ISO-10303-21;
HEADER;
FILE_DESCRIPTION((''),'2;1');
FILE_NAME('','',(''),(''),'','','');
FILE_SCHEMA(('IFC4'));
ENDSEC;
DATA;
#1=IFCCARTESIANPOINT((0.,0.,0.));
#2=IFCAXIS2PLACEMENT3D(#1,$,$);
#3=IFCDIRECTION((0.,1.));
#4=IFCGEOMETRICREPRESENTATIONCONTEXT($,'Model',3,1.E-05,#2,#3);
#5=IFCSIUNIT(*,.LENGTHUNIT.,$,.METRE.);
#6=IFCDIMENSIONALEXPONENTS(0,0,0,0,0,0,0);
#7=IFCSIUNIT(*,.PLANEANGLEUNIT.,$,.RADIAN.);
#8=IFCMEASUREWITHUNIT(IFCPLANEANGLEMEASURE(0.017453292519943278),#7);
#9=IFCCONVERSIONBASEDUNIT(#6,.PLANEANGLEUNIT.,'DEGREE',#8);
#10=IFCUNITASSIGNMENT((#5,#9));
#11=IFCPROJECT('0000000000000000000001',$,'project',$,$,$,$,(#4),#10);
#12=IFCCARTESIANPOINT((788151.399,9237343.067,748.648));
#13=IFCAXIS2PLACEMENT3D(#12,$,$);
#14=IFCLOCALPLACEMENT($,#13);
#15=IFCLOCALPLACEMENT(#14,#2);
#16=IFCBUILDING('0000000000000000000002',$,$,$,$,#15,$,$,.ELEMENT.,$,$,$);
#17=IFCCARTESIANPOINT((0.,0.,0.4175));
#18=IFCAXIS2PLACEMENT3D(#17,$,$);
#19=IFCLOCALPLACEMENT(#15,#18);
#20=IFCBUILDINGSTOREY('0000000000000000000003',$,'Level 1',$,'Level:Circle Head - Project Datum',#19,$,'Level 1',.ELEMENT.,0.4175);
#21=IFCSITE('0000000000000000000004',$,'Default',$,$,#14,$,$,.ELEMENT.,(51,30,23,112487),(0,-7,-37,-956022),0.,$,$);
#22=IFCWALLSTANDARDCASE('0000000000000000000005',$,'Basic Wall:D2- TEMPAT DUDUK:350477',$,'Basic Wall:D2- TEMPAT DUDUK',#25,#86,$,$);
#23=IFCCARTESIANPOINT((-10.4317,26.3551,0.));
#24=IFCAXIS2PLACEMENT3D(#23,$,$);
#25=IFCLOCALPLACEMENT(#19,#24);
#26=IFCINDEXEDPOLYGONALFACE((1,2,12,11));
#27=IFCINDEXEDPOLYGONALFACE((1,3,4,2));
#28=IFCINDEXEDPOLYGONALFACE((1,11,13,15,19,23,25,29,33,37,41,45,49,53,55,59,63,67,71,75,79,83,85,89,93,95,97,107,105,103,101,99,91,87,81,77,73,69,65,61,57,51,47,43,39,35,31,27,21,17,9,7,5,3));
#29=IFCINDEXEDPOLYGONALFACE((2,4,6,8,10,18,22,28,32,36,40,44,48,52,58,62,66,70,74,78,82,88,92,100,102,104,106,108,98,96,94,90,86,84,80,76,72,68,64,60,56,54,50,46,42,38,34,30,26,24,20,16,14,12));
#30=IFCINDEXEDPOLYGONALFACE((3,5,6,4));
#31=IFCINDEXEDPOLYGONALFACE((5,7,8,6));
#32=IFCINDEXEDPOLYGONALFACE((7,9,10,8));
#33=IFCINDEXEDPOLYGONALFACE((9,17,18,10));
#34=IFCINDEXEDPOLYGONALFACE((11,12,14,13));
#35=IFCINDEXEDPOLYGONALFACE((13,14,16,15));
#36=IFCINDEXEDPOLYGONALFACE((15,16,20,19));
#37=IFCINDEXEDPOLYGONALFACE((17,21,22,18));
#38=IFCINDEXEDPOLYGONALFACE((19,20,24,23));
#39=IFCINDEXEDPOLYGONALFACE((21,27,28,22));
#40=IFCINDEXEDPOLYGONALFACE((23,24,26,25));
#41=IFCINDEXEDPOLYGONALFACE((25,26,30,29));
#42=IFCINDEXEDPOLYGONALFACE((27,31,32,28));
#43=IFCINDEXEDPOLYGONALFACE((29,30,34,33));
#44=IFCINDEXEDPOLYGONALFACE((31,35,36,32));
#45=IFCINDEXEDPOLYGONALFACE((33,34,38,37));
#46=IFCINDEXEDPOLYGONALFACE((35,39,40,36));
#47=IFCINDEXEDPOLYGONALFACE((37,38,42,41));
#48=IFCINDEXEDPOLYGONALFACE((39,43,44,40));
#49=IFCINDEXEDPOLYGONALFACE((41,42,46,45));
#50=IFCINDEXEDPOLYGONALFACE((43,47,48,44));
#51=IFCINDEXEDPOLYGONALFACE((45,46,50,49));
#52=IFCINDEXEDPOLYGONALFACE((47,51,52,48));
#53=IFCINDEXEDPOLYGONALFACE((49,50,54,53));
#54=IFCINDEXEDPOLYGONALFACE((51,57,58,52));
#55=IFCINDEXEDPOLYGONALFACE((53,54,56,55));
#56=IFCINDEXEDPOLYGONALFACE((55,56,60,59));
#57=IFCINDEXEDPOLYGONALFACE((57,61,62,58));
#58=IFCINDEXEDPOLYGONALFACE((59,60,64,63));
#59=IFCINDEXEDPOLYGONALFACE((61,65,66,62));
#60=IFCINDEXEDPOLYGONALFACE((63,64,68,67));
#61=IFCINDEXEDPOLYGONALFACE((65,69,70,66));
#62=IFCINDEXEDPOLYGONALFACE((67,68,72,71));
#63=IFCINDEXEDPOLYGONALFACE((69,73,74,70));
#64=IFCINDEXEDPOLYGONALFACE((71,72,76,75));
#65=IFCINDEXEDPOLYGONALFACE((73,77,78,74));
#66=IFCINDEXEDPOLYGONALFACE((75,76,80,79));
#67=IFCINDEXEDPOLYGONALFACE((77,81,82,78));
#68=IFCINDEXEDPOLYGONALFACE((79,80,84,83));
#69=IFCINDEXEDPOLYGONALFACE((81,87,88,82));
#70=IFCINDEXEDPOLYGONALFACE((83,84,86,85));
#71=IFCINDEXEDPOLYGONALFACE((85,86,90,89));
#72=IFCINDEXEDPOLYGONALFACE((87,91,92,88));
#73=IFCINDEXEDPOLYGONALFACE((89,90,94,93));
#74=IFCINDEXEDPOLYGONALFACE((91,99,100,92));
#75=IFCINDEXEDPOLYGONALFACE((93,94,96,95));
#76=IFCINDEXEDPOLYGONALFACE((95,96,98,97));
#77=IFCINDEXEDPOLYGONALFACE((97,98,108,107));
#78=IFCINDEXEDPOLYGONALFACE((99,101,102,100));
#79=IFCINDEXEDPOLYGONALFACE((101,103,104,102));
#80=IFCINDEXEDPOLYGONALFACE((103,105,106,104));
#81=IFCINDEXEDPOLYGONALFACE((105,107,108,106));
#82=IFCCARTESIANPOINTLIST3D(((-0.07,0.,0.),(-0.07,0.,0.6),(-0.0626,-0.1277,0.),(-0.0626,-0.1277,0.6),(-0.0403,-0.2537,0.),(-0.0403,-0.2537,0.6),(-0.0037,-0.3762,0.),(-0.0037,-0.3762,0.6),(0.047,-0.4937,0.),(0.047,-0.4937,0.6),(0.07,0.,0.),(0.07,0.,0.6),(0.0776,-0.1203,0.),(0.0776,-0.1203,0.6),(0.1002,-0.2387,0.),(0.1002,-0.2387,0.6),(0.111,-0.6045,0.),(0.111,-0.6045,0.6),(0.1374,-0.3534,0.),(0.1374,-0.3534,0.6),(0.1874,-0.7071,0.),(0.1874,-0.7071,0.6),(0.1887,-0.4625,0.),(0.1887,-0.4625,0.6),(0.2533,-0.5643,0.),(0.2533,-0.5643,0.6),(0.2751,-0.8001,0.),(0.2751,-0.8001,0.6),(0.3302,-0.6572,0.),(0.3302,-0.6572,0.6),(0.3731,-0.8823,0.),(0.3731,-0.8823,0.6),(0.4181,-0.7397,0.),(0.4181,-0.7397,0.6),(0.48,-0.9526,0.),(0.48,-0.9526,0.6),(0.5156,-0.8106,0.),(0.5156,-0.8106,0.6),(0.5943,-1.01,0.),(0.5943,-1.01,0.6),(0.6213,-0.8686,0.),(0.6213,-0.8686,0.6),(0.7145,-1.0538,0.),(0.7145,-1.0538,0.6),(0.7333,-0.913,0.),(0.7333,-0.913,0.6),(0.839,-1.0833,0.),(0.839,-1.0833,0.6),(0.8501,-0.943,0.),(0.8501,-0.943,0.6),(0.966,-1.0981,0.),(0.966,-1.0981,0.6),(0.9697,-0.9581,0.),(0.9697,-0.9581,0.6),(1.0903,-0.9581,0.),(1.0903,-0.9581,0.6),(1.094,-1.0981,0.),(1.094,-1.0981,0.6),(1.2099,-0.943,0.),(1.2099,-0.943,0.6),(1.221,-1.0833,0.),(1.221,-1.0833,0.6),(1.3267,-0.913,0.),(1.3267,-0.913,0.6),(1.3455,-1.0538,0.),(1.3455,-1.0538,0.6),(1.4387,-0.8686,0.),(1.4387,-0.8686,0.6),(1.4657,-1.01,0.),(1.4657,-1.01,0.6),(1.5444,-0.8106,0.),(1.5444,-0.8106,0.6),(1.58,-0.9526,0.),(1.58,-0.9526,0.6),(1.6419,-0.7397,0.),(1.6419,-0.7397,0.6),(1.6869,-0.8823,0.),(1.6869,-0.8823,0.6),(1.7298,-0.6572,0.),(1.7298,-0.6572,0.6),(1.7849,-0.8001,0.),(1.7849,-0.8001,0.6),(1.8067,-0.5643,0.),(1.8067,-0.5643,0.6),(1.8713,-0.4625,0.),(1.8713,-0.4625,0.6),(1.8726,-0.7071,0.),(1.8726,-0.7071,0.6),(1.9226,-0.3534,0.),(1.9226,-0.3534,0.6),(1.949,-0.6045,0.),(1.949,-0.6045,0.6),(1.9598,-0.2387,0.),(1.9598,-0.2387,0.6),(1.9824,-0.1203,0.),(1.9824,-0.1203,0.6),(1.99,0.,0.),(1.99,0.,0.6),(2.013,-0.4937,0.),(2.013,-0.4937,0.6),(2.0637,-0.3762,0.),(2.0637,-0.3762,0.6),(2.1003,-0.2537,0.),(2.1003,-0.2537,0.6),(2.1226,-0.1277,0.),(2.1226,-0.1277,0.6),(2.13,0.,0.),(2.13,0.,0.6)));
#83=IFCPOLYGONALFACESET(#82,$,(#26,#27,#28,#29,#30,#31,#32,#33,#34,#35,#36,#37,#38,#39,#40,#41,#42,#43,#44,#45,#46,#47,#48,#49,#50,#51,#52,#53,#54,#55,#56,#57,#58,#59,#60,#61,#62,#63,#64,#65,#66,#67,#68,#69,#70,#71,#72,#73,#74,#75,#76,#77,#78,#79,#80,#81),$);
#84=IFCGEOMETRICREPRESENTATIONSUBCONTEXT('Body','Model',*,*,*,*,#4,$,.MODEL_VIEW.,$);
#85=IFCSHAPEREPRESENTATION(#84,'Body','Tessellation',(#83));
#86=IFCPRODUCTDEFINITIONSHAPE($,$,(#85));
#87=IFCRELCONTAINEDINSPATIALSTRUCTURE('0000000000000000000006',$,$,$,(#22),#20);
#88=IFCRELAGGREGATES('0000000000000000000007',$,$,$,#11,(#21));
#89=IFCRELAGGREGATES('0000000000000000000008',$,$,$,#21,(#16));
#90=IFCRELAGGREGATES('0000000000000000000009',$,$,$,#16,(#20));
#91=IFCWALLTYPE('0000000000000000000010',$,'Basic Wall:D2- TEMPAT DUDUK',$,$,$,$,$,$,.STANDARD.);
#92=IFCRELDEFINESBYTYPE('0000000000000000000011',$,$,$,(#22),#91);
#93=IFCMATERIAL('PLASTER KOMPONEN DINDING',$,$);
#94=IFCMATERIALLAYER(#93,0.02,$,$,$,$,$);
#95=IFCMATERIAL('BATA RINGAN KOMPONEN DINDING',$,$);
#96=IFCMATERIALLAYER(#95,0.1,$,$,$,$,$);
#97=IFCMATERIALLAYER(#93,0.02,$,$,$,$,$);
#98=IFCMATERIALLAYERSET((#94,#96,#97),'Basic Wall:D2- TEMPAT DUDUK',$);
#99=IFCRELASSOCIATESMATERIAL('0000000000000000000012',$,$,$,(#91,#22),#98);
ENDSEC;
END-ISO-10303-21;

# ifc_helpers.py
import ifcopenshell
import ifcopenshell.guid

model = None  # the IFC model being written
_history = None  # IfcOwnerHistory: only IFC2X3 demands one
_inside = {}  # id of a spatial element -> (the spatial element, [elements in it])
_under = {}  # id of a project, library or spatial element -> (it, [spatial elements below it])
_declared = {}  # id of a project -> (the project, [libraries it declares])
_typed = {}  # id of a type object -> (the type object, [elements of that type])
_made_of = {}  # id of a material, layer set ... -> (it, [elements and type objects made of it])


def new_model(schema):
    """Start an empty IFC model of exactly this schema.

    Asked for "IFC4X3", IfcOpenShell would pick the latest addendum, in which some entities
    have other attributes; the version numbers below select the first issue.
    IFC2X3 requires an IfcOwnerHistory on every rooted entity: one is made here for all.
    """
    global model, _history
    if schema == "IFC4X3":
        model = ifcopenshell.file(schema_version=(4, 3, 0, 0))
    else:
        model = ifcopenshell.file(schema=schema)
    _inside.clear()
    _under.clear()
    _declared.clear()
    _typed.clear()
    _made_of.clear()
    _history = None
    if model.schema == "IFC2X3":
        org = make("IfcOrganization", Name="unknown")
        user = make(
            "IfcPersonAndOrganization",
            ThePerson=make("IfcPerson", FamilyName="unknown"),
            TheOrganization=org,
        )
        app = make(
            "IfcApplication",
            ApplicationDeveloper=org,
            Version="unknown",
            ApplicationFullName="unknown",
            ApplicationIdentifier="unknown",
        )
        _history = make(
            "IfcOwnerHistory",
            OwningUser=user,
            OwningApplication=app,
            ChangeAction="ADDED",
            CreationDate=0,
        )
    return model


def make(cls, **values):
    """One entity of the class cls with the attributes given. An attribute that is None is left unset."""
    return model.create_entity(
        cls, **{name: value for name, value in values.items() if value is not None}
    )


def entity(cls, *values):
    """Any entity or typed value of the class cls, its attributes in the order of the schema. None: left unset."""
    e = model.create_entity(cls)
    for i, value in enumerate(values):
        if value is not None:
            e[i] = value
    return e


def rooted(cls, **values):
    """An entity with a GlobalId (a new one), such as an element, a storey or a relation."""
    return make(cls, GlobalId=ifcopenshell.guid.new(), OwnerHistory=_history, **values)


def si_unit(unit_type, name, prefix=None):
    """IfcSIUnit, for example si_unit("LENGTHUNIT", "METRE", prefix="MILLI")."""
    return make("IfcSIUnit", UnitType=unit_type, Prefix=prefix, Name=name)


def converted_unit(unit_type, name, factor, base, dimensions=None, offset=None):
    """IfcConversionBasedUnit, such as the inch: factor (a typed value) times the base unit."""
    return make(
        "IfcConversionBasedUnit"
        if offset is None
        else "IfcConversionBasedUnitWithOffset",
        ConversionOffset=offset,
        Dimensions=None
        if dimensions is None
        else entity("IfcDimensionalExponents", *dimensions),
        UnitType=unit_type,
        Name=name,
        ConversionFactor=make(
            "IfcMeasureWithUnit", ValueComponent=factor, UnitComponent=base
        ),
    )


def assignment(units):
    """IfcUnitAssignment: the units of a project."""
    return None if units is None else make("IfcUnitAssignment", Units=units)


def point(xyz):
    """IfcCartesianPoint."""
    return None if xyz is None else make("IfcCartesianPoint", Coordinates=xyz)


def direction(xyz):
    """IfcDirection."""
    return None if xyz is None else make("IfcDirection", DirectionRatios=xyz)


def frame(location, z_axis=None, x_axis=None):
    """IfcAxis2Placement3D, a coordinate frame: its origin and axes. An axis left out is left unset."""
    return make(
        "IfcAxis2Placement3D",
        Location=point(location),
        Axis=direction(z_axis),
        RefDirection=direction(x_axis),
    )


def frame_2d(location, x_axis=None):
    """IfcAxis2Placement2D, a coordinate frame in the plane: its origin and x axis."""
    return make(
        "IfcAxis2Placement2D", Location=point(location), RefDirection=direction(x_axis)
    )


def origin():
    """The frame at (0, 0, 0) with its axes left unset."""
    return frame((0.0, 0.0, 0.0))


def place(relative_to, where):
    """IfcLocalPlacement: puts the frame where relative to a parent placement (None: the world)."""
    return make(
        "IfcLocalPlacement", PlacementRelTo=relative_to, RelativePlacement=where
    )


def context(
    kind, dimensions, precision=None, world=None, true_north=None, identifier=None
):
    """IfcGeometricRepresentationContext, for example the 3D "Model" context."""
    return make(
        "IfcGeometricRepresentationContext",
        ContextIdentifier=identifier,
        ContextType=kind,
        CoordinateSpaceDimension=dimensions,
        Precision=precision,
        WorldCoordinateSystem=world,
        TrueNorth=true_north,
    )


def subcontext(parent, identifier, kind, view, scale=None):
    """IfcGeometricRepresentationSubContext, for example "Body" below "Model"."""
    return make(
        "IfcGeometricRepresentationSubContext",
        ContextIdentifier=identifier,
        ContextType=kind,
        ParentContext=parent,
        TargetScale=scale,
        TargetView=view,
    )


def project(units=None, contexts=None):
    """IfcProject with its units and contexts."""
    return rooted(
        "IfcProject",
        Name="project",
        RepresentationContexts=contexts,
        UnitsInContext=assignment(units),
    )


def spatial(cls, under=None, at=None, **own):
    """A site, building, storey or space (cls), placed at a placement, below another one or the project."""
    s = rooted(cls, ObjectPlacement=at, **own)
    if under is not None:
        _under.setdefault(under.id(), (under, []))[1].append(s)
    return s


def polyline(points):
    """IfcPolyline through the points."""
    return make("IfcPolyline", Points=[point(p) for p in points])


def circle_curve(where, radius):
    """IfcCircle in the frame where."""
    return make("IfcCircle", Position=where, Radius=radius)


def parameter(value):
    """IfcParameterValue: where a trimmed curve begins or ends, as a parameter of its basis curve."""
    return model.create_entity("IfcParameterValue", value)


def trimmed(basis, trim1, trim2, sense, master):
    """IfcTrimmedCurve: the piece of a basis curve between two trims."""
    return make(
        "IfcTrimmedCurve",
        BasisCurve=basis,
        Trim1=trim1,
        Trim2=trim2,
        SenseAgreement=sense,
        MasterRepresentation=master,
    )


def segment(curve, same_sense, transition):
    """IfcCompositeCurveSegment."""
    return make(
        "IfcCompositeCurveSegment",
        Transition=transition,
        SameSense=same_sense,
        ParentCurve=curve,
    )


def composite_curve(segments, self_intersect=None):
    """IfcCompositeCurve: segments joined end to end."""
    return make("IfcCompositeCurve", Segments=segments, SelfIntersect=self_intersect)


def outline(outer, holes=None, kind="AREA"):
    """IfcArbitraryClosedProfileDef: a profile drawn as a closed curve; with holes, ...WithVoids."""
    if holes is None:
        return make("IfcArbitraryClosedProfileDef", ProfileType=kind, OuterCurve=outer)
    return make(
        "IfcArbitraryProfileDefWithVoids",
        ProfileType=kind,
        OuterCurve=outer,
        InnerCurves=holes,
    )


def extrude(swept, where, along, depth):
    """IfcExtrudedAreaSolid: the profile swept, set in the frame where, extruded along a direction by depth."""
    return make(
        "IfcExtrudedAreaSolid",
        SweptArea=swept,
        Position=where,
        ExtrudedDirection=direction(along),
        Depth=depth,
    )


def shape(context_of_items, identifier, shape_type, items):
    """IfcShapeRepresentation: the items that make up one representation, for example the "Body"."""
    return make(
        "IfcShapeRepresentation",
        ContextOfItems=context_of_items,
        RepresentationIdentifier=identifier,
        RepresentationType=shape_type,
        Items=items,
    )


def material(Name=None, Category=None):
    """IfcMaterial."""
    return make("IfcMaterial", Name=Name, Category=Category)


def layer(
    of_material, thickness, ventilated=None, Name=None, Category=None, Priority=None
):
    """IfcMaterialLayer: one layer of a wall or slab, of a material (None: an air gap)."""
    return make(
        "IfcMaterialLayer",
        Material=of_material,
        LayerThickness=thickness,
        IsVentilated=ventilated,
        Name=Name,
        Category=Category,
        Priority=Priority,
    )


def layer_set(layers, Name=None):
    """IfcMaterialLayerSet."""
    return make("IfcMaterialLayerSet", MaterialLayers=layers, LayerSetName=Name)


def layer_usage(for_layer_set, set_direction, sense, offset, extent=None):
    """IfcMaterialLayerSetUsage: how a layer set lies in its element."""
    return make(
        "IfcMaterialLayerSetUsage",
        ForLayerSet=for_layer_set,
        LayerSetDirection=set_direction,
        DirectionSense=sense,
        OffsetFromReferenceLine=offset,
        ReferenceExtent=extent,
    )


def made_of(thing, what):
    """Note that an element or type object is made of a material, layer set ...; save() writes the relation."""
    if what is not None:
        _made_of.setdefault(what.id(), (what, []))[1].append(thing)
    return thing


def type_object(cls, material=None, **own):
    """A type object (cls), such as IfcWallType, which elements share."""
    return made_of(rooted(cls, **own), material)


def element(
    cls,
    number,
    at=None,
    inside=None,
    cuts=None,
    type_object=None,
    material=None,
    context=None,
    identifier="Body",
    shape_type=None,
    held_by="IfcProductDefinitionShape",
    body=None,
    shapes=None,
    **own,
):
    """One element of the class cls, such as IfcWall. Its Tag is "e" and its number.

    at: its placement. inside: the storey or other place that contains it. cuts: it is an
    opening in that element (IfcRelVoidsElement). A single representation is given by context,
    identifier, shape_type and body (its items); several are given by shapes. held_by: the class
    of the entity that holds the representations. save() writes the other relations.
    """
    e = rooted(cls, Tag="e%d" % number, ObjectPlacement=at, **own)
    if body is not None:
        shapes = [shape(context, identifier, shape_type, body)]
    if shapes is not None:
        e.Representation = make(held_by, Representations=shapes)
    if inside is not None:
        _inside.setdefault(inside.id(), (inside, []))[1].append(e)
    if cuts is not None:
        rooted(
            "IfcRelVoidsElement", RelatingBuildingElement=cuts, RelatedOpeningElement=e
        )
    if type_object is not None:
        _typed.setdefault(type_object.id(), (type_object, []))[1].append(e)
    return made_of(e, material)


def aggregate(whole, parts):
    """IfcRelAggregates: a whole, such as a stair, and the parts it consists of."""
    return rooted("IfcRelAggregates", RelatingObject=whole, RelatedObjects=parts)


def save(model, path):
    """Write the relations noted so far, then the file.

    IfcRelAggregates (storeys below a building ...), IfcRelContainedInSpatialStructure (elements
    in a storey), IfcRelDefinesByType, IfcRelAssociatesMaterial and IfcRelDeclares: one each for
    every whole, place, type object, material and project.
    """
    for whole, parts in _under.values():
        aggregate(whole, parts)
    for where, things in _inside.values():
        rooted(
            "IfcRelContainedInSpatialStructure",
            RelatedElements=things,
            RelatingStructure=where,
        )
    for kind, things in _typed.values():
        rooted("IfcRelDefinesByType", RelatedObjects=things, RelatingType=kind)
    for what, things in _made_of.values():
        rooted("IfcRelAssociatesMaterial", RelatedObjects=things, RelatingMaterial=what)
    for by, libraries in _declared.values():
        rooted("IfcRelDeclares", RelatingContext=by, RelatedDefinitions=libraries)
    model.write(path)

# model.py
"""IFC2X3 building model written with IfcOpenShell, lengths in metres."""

from ifc_helpers import new_model, entity, si_unit, converted_unit, direction, frame, frame_2d, origin, place, context, subcontext, project, spatial, polyline, circle_curve, parameter, trimmed, segment, composite_curve, outline, extrude, material, layer, layer_set, layer_usage, type_object, element, save


model = new_model("IFC2X3")

# Units and contexts
model_context = context("Model", 3, precision=1e-05, world=origin(), true_north=direction((0.0, 1.0)))
body_context = subcontext(model_context, "Body", "Model", "MODEL_VIEW")
ifc_project = project(units=[si_unit("LENGTHUNIT", "METRE"), converted_unit("PLANEANGLEUNIT", "DEGREE", entity("IfcPlaneAngleMeasure", 0.017453292519943278), si_unit("PLANEANGLEUNIT", "RADIAN"), dimensions=[0, 0, 0, 0, 0, 0, 0])], contexts=[model_context])

# Site, building, storey
site_placement = place(None, frame((788151.399, 9237343.067, 748.648)))
site = spatial("IfcSite", under=ifc_project, at=site_placement, Name="Default", CompositionType="ELEMENT", RefLatitude=(51, 30, 23, 112487), RefLongitude=(0, -7, -37, -956022), RefElevation=0.0)
building_placement = place(site_placement, origin())
building = spatial("IfcBuilding", under=site, at=building_placement, CompositionType="ELEMENT")
storey_placement = place(building_placement, frame((0.0, 0.0, 0.4175)))
storey = spatial("IfcBuildingStorey", under=building, at=storey_placement, Name="Level 1", ObjectType="Level:Circle Head - Project Datum", LongName="Level 1", CompositionType="ELEMENT", Elevation=0.4175)

# Wall
ifc_material_1 = material(Name="PLASTER KOMPONEN DINDING")
ifc_material_2 = material(Name="BATA RINGAN KOMPONEN DINDING")
ifc_layer_1 = layer(ifc_material_1, 0.02)
ifc_layer_2 = layer(ifc_material_2, 0.1)
ifc_layer_3 = layer(ifc_material_1, 0.02)
ifc_layer_set_1 = layer_set([ifc_layer_1, ifc_layer_2, ifc_layer_3], Name="Basic Wall:D2- TEMPAT DUDUK")
wall_type_1 = type_object("IfcWallType", Name="Basic Wall:D2- TEMPAT DUDUK", PredefinedType="STANDARD", material=ifc_layer_set_1)
ifc_layer_usage_1 = layer_usage(ifc_layer_set_1, "AXIS2", "NEGATIVE", 0.07)
wall_1_placement = place(storey_placement, frame((-10.4317, 26.3551, 0.0)))
element("IfcWallStandardCase", 1, at=wall_1_placement, inside=storey, type_object=wall_type_1, material=ifc_layer_usage_1, Name="Basic Wall:D2- TEMPAT DUDUK:350477", ObjectType="Basic Wall:D2- TEMPAT DUDUK", context=body_context, shape_type="SweptSolid", body=[
    extrude(outline(composite_curve([segment(trimmed(circle_curve(frame_2d((1.03, 0.0), x_axis=(1.0, 0.0)), 0.96), [parameter(180.0)], [parameter(0.0)], True, "PARAMETER"), False, "CONTINUOUS"), segment(polyline([(0.07, 0.0), (-0.07, 0.0)]), True, "CONTINUOUS"), segment(trimmed(circle_curve(frame_2d((1.03, 0.0), x_axis=(1.0, 0.0)), 1.1), [parameter(180.0)], [parameter(0.0)], True, "PARAMETER"), True, "CONTINUOUS"), segment(polyline([(2.13, 0.0), (1.99, 0.0)]), True, "CONTINUOUS")], self_intersect=False)), origin(), (0.0, 0.0, 1.0), 0.6),
])

save(model, "model.ifc")
